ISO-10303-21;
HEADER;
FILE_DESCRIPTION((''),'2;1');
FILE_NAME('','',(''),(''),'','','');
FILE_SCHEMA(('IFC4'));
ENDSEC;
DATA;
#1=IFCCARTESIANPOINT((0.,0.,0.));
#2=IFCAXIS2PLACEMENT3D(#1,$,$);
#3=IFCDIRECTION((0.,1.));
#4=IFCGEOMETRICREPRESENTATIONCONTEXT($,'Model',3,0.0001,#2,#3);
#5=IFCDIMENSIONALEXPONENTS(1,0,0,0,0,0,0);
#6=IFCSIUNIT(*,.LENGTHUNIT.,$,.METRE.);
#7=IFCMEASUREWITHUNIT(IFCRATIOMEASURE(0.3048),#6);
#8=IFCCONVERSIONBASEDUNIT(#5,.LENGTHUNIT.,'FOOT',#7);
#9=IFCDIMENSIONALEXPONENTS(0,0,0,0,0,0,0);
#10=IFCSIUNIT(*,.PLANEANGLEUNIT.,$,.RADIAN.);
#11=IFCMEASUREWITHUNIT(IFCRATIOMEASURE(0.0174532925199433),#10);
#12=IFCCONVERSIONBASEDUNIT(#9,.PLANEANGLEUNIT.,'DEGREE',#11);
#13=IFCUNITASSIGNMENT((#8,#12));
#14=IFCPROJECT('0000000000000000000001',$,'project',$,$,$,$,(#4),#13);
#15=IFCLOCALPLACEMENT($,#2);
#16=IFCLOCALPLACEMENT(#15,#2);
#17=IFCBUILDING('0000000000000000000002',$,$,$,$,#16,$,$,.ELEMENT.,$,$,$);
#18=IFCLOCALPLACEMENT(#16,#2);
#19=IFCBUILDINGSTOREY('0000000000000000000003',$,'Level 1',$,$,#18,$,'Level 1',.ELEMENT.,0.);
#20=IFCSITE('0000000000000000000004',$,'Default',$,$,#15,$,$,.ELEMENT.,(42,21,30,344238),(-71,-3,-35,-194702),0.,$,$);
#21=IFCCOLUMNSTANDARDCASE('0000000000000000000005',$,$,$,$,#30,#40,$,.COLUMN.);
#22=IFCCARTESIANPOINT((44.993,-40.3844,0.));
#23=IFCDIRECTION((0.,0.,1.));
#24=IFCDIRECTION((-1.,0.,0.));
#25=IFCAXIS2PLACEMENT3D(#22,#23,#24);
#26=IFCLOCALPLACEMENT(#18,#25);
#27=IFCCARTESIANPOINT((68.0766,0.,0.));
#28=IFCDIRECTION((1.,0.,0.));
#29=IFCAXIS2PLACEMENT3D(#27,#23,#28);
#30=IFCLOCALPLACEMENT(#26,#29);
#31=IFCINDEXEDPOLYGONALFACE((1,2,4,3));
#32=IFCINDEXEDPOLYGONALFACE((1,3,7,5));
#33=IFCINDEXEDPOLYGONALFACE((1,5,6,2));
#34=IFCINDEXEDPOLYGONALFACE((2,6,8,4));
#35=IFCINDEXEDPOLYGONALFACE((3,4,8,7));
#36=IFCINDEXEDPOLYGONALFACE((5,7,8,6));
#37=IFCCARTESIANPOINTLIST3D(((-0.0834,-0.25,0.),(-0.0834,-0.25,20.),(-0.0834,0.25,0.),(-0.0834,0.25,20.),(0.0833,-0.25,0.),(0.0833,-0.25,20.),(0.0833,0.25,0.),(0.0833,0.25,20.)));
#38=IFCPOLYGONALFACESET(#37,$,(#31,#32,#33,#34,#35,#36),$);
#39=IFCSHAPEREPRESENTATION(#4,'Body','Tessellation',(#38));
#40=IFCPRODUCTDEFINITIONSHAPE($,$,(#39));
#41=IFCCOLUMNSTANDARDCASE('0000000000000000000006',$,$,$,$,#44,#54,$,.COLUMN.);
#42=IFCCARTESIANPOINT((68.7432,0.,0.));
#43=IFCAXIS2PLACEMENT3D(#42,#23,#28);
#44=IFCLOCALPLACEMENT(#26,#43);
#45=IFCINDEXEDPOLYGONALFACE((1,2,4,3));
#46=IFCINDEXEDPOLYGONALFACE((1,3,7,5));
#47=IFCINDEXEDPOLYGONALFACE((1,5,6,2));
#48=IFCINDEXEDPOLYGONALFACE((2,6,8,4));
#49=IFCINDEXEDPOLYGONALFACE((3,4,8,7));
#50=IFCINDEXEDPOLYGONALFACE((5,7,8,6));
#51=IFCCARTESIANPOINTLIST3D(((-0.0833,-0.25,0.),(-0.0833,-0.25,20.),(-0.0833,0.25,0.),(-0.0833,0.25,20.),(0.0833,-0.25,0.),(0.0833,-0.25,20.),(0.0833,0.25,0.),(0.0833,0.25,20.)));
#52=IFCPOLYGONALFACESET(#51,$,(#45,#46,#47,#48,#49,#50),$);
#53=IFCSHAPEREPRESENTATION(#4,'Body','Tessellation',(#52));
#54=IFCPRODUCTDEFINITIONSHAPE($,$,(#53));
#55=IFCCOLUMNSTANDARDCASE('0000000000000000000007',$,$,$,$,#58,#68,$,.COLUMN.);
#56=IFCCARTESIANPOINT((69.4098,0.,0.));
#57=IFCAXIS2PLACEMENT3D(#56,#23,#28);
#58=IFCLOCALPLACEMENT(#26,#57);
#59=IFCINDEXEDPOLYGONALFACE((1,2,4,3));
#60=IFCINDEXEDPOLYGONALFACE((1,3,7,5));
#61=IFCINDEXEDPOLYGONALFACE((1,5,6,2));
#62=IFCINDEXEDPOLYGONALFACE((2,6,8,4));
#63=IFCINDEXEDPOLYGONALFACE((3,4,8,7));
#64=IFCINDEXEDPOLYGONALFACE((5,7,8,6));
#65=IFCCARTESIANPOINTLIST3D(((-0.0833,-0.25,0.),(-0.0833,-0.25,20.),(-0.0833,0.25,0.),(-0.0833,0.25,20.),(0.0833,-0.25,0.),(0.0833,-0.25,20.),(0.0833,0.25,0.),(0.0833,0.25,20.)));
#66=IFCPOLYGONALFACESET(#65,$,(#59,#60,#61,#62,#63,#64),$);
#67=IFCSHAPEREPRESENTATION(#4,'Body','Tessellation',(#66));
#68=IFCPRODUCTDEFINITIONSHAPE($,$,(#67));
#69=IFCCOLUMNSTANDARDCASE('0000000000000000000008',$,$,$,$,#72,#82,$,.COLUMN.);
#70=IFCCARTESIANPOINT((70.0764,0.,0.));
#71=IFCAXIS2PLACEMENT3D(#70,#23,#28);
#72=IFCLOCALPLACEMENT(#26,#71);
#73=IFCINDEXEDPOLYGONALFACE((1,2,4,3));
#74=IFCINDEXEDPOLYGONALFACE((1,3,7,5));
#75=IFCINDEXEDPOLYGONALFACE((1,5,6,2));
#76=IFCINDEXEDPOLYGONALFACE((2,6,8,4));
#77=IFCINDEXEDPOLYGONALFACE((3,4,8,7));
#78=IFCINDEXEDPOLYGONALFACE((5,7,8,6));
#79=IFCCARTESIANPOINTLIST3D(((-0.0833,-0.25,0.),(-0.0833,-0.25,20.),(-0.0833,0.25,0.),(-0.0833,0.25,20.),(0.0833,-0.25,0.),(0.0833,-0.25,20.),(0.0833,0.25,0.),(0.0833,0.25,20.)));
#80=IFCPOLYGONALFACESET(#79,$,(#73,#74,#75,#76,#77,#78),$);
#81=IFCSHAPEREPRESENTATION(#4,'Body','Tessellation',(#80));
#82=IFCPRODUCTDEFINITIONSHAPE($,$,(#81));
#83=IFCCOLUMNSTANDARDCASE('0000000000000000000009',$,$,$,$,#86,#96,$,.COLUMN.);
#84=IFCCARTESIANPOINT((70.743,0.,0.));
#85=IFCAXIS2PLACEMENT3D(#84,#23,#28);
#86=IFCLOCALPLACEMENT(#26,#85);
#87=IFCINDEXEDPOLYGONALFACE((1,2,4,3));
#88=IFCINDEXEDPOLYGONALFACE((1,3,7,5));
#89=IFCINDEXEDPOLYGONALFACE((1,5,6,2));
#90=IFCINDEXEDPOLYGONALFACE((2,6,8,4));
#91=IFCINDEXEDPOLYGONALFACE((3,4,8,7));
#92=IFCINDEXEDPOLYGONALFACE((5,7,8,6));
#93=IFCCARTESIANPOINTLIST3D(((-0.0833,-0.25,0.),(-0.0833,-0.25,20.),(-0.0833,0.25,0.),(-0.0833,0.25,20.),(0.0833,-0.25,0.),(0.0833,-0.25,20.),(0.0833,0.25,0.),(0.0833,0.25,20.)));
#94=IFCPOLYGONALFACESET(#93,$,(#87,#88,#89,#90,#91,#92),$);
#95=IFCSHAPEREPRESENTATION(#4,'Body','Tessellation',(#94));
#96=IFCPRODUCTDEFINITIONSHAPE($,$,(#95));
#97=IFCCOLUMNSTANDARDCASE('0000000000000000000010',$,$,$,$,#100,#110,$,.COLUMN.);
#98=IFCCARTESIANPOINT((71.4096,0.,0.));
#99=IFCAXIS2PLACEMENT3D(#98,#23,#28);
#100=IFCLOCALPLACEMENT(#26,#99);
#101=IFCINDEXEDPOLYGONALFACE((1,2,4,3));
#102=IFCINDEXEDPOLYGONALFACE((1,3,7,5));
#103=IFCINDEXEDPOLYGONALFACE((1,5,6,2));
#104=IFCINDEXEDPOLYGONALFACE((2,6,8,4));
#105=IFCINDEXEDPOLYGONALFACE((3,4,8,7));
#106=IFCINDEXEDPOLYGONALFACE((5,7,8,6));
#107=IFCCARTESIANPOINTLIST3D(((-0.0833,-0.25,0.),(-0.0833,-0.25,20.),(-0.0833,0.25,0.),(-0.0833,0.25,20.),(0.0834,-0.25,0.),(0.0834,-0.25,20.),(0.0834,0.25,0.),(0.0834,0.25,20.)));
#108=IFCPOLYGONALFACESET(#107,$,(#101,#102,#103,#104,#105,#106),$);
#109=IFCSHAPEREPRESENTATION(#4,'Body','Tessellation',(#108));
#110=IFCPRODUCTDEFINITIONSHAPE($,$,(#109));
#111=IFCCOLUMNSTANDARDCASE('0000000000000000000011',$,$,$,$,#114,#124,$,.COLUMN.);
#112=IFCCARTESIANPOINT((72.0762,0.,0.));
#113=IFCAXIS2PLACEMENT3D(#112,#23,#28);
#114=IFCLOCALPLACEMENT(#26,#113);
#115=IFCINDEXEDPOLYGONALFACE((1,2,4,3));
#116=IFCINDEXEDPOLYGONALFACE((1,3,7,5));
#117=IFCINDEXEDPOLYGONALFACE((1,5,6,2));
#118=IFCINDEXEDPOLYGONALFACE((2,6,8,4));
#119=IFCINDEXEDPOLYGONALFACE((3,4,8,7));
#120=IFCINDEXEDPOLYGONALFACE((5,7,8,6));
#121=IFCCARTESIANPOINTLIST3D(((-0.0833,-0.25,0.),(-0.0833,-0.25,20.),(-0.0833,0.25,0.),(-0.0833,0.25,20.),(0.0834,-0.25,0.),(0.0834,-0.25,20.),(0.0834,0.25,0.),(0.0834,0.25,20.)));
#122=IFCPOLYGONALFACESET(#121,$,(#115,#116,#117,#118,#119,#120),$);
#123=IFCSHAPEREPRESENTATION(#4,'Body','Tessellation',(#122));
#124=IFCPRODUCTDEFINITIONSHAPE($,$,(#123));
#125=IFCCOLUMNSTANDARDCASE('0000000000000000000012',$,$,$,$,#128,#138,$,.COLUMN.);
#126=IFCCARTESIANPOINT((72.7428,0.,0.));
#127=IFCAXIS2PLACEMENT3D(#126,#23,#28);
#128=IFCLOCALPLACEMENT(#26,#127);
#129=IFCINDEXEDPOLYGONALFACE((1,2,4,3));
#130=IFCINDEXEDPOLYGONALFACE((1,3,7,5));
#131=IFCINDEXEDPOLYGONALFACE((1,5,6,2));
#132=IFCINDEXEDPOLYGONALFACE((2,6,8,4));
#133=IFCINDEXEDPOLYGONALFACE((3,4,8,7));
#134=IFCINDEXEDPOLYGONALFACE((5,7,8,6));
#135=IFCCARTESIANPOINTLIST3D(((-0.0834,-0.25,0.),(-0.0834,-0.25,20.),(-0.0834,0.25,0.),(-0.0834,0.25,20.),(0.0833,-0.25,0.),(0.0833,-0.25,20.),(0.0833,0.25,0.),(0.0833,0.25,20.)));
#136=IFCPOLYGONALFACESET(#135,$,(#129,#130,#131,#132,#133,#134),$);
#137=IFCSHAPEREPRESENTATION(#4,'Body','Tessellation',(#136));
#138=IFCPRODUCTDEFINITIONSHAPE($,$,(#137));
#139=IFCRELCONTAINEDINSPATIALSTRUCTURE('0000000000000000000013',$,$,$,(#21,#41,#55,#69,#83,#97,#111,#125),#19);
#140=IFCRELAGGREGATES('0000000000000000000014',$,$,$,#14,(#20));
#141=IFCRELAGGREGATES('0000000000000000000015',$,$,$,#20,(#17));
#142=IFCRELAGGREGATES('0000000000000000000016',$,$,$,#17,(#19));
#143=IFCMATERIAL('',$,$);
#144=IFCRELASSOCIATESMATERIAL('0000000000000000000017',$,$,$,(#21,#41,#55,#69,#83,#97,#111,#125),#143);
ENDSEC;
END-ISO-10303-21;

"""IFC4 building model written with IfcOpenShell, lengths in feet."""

from ifc_helpers import new_model, entity, si_unit, converted_unit, direction, frame, origin, place, context, project, spatial, rectangle, extrude, material, element, save


model = new_model("IFC4")

# Units and contexts
model_context = context("Model", 3, precision=0.0001, world=origin(), true_north=direction((0.0, 1.0)))
ifc_project = project(units=[converted_unit("LENGTHUNIT", "FOOT", entity("IfcRatioMeasure", 0.3048), si_unit("LENGTHUNIT", "METRE"), dimensions=[1, 0, 0, 0, 0, 0, 0]), converted_unit("PLANEANGLEUNIT", "DEGREE", entity("IfcRatioMeasure", 0.0174532925199433), si_unit("PLANEANGLEUNIT", "RADIAN"), dimensions=[0, 0, 0, 0, 0, 0, 0])], contexts=[model_context])

# Site, building, storey
site_placement = place(None, origin())
site = spatial("IfcSite", under=ifc_project, at=site_placement, Name="Default", CompositionType="ELEMENT", RefLatitude=(42, 21, 30, 344238), RefLongitude=(-71, -3, -35, -194702), RefElevation=0.0)
building_placement = place(site_placement, origin())
building = spatial("IfcBuilding", under=site, at=building_placement, CompositionType="ELEMENT")
storey_placement = place(building_placement, origin())
storey = spatial("IfcBuildingStorey", under=building, at=storey_placement, Name="Level 1", LongName="Level 1", CompositionType="ELEMENT", Elevation=0.0)

# Columns
ifc_material_1 = material(Name="")
placement = place(storey_placement, frame((44.993, -40.3844, 0.0), z_axis=(0.0, 0.0, 1.0), x_axis=(-1.0, 0.0, 0.0)))
for number, where, z_axis, x_axis in (
    (1, (68.0766, 0.0, 0.0), (0.0, 0.0, 1.0), (1.0, 0.0, 0.0)),
    (2, (68.7432, 0.0, 0.0), (0.0, 0.0, 1.0), (1.0, 0.0, 0.0)),
    (3, (69.4098, 0.0, 0.0), (0.0, 0.0, 1.0), (1.0, 0.0, 0.0)),
    (4, (70.0764, 0.0, 0.0), (0.0, 0.0, 1.0), (1.0, 0.0, 0.0)),
    (5, (70.743, 0.0, 0.0), (0.0, 0.0, 1.0), (1.0, 0.0, 0.0)),
    (6, (71.4096, 0.0, 0.0), (0.0, 0.0, 1.0), (1.0, 0.0, 0.0)),
    (7, (72.0762, 0.0, 0.0), (0.0, 0.0, 1.0), (1.0, 0.0, 0.0)),
    (8, (72.7428, 0.0, 0.0), (0.0, 0.0, 1.0), (1.0, 0.0, 0.0)),
):
    element("IfcColumnStandardCase", number, at=place(placement, frame(where, z_axis=z_axis, x_axis=x_axis)), inside=storey, material=ifc_material_1, PredefinedType="COLUMN", context=model_context, shape_type="SweptSolid", body=[
        extrude(rectangle(XDim=0.1667, YDim=0.5), origin(), (0.0, 0.0, 1.0), 20.0),
    ])

save(model, "model.ifc")
